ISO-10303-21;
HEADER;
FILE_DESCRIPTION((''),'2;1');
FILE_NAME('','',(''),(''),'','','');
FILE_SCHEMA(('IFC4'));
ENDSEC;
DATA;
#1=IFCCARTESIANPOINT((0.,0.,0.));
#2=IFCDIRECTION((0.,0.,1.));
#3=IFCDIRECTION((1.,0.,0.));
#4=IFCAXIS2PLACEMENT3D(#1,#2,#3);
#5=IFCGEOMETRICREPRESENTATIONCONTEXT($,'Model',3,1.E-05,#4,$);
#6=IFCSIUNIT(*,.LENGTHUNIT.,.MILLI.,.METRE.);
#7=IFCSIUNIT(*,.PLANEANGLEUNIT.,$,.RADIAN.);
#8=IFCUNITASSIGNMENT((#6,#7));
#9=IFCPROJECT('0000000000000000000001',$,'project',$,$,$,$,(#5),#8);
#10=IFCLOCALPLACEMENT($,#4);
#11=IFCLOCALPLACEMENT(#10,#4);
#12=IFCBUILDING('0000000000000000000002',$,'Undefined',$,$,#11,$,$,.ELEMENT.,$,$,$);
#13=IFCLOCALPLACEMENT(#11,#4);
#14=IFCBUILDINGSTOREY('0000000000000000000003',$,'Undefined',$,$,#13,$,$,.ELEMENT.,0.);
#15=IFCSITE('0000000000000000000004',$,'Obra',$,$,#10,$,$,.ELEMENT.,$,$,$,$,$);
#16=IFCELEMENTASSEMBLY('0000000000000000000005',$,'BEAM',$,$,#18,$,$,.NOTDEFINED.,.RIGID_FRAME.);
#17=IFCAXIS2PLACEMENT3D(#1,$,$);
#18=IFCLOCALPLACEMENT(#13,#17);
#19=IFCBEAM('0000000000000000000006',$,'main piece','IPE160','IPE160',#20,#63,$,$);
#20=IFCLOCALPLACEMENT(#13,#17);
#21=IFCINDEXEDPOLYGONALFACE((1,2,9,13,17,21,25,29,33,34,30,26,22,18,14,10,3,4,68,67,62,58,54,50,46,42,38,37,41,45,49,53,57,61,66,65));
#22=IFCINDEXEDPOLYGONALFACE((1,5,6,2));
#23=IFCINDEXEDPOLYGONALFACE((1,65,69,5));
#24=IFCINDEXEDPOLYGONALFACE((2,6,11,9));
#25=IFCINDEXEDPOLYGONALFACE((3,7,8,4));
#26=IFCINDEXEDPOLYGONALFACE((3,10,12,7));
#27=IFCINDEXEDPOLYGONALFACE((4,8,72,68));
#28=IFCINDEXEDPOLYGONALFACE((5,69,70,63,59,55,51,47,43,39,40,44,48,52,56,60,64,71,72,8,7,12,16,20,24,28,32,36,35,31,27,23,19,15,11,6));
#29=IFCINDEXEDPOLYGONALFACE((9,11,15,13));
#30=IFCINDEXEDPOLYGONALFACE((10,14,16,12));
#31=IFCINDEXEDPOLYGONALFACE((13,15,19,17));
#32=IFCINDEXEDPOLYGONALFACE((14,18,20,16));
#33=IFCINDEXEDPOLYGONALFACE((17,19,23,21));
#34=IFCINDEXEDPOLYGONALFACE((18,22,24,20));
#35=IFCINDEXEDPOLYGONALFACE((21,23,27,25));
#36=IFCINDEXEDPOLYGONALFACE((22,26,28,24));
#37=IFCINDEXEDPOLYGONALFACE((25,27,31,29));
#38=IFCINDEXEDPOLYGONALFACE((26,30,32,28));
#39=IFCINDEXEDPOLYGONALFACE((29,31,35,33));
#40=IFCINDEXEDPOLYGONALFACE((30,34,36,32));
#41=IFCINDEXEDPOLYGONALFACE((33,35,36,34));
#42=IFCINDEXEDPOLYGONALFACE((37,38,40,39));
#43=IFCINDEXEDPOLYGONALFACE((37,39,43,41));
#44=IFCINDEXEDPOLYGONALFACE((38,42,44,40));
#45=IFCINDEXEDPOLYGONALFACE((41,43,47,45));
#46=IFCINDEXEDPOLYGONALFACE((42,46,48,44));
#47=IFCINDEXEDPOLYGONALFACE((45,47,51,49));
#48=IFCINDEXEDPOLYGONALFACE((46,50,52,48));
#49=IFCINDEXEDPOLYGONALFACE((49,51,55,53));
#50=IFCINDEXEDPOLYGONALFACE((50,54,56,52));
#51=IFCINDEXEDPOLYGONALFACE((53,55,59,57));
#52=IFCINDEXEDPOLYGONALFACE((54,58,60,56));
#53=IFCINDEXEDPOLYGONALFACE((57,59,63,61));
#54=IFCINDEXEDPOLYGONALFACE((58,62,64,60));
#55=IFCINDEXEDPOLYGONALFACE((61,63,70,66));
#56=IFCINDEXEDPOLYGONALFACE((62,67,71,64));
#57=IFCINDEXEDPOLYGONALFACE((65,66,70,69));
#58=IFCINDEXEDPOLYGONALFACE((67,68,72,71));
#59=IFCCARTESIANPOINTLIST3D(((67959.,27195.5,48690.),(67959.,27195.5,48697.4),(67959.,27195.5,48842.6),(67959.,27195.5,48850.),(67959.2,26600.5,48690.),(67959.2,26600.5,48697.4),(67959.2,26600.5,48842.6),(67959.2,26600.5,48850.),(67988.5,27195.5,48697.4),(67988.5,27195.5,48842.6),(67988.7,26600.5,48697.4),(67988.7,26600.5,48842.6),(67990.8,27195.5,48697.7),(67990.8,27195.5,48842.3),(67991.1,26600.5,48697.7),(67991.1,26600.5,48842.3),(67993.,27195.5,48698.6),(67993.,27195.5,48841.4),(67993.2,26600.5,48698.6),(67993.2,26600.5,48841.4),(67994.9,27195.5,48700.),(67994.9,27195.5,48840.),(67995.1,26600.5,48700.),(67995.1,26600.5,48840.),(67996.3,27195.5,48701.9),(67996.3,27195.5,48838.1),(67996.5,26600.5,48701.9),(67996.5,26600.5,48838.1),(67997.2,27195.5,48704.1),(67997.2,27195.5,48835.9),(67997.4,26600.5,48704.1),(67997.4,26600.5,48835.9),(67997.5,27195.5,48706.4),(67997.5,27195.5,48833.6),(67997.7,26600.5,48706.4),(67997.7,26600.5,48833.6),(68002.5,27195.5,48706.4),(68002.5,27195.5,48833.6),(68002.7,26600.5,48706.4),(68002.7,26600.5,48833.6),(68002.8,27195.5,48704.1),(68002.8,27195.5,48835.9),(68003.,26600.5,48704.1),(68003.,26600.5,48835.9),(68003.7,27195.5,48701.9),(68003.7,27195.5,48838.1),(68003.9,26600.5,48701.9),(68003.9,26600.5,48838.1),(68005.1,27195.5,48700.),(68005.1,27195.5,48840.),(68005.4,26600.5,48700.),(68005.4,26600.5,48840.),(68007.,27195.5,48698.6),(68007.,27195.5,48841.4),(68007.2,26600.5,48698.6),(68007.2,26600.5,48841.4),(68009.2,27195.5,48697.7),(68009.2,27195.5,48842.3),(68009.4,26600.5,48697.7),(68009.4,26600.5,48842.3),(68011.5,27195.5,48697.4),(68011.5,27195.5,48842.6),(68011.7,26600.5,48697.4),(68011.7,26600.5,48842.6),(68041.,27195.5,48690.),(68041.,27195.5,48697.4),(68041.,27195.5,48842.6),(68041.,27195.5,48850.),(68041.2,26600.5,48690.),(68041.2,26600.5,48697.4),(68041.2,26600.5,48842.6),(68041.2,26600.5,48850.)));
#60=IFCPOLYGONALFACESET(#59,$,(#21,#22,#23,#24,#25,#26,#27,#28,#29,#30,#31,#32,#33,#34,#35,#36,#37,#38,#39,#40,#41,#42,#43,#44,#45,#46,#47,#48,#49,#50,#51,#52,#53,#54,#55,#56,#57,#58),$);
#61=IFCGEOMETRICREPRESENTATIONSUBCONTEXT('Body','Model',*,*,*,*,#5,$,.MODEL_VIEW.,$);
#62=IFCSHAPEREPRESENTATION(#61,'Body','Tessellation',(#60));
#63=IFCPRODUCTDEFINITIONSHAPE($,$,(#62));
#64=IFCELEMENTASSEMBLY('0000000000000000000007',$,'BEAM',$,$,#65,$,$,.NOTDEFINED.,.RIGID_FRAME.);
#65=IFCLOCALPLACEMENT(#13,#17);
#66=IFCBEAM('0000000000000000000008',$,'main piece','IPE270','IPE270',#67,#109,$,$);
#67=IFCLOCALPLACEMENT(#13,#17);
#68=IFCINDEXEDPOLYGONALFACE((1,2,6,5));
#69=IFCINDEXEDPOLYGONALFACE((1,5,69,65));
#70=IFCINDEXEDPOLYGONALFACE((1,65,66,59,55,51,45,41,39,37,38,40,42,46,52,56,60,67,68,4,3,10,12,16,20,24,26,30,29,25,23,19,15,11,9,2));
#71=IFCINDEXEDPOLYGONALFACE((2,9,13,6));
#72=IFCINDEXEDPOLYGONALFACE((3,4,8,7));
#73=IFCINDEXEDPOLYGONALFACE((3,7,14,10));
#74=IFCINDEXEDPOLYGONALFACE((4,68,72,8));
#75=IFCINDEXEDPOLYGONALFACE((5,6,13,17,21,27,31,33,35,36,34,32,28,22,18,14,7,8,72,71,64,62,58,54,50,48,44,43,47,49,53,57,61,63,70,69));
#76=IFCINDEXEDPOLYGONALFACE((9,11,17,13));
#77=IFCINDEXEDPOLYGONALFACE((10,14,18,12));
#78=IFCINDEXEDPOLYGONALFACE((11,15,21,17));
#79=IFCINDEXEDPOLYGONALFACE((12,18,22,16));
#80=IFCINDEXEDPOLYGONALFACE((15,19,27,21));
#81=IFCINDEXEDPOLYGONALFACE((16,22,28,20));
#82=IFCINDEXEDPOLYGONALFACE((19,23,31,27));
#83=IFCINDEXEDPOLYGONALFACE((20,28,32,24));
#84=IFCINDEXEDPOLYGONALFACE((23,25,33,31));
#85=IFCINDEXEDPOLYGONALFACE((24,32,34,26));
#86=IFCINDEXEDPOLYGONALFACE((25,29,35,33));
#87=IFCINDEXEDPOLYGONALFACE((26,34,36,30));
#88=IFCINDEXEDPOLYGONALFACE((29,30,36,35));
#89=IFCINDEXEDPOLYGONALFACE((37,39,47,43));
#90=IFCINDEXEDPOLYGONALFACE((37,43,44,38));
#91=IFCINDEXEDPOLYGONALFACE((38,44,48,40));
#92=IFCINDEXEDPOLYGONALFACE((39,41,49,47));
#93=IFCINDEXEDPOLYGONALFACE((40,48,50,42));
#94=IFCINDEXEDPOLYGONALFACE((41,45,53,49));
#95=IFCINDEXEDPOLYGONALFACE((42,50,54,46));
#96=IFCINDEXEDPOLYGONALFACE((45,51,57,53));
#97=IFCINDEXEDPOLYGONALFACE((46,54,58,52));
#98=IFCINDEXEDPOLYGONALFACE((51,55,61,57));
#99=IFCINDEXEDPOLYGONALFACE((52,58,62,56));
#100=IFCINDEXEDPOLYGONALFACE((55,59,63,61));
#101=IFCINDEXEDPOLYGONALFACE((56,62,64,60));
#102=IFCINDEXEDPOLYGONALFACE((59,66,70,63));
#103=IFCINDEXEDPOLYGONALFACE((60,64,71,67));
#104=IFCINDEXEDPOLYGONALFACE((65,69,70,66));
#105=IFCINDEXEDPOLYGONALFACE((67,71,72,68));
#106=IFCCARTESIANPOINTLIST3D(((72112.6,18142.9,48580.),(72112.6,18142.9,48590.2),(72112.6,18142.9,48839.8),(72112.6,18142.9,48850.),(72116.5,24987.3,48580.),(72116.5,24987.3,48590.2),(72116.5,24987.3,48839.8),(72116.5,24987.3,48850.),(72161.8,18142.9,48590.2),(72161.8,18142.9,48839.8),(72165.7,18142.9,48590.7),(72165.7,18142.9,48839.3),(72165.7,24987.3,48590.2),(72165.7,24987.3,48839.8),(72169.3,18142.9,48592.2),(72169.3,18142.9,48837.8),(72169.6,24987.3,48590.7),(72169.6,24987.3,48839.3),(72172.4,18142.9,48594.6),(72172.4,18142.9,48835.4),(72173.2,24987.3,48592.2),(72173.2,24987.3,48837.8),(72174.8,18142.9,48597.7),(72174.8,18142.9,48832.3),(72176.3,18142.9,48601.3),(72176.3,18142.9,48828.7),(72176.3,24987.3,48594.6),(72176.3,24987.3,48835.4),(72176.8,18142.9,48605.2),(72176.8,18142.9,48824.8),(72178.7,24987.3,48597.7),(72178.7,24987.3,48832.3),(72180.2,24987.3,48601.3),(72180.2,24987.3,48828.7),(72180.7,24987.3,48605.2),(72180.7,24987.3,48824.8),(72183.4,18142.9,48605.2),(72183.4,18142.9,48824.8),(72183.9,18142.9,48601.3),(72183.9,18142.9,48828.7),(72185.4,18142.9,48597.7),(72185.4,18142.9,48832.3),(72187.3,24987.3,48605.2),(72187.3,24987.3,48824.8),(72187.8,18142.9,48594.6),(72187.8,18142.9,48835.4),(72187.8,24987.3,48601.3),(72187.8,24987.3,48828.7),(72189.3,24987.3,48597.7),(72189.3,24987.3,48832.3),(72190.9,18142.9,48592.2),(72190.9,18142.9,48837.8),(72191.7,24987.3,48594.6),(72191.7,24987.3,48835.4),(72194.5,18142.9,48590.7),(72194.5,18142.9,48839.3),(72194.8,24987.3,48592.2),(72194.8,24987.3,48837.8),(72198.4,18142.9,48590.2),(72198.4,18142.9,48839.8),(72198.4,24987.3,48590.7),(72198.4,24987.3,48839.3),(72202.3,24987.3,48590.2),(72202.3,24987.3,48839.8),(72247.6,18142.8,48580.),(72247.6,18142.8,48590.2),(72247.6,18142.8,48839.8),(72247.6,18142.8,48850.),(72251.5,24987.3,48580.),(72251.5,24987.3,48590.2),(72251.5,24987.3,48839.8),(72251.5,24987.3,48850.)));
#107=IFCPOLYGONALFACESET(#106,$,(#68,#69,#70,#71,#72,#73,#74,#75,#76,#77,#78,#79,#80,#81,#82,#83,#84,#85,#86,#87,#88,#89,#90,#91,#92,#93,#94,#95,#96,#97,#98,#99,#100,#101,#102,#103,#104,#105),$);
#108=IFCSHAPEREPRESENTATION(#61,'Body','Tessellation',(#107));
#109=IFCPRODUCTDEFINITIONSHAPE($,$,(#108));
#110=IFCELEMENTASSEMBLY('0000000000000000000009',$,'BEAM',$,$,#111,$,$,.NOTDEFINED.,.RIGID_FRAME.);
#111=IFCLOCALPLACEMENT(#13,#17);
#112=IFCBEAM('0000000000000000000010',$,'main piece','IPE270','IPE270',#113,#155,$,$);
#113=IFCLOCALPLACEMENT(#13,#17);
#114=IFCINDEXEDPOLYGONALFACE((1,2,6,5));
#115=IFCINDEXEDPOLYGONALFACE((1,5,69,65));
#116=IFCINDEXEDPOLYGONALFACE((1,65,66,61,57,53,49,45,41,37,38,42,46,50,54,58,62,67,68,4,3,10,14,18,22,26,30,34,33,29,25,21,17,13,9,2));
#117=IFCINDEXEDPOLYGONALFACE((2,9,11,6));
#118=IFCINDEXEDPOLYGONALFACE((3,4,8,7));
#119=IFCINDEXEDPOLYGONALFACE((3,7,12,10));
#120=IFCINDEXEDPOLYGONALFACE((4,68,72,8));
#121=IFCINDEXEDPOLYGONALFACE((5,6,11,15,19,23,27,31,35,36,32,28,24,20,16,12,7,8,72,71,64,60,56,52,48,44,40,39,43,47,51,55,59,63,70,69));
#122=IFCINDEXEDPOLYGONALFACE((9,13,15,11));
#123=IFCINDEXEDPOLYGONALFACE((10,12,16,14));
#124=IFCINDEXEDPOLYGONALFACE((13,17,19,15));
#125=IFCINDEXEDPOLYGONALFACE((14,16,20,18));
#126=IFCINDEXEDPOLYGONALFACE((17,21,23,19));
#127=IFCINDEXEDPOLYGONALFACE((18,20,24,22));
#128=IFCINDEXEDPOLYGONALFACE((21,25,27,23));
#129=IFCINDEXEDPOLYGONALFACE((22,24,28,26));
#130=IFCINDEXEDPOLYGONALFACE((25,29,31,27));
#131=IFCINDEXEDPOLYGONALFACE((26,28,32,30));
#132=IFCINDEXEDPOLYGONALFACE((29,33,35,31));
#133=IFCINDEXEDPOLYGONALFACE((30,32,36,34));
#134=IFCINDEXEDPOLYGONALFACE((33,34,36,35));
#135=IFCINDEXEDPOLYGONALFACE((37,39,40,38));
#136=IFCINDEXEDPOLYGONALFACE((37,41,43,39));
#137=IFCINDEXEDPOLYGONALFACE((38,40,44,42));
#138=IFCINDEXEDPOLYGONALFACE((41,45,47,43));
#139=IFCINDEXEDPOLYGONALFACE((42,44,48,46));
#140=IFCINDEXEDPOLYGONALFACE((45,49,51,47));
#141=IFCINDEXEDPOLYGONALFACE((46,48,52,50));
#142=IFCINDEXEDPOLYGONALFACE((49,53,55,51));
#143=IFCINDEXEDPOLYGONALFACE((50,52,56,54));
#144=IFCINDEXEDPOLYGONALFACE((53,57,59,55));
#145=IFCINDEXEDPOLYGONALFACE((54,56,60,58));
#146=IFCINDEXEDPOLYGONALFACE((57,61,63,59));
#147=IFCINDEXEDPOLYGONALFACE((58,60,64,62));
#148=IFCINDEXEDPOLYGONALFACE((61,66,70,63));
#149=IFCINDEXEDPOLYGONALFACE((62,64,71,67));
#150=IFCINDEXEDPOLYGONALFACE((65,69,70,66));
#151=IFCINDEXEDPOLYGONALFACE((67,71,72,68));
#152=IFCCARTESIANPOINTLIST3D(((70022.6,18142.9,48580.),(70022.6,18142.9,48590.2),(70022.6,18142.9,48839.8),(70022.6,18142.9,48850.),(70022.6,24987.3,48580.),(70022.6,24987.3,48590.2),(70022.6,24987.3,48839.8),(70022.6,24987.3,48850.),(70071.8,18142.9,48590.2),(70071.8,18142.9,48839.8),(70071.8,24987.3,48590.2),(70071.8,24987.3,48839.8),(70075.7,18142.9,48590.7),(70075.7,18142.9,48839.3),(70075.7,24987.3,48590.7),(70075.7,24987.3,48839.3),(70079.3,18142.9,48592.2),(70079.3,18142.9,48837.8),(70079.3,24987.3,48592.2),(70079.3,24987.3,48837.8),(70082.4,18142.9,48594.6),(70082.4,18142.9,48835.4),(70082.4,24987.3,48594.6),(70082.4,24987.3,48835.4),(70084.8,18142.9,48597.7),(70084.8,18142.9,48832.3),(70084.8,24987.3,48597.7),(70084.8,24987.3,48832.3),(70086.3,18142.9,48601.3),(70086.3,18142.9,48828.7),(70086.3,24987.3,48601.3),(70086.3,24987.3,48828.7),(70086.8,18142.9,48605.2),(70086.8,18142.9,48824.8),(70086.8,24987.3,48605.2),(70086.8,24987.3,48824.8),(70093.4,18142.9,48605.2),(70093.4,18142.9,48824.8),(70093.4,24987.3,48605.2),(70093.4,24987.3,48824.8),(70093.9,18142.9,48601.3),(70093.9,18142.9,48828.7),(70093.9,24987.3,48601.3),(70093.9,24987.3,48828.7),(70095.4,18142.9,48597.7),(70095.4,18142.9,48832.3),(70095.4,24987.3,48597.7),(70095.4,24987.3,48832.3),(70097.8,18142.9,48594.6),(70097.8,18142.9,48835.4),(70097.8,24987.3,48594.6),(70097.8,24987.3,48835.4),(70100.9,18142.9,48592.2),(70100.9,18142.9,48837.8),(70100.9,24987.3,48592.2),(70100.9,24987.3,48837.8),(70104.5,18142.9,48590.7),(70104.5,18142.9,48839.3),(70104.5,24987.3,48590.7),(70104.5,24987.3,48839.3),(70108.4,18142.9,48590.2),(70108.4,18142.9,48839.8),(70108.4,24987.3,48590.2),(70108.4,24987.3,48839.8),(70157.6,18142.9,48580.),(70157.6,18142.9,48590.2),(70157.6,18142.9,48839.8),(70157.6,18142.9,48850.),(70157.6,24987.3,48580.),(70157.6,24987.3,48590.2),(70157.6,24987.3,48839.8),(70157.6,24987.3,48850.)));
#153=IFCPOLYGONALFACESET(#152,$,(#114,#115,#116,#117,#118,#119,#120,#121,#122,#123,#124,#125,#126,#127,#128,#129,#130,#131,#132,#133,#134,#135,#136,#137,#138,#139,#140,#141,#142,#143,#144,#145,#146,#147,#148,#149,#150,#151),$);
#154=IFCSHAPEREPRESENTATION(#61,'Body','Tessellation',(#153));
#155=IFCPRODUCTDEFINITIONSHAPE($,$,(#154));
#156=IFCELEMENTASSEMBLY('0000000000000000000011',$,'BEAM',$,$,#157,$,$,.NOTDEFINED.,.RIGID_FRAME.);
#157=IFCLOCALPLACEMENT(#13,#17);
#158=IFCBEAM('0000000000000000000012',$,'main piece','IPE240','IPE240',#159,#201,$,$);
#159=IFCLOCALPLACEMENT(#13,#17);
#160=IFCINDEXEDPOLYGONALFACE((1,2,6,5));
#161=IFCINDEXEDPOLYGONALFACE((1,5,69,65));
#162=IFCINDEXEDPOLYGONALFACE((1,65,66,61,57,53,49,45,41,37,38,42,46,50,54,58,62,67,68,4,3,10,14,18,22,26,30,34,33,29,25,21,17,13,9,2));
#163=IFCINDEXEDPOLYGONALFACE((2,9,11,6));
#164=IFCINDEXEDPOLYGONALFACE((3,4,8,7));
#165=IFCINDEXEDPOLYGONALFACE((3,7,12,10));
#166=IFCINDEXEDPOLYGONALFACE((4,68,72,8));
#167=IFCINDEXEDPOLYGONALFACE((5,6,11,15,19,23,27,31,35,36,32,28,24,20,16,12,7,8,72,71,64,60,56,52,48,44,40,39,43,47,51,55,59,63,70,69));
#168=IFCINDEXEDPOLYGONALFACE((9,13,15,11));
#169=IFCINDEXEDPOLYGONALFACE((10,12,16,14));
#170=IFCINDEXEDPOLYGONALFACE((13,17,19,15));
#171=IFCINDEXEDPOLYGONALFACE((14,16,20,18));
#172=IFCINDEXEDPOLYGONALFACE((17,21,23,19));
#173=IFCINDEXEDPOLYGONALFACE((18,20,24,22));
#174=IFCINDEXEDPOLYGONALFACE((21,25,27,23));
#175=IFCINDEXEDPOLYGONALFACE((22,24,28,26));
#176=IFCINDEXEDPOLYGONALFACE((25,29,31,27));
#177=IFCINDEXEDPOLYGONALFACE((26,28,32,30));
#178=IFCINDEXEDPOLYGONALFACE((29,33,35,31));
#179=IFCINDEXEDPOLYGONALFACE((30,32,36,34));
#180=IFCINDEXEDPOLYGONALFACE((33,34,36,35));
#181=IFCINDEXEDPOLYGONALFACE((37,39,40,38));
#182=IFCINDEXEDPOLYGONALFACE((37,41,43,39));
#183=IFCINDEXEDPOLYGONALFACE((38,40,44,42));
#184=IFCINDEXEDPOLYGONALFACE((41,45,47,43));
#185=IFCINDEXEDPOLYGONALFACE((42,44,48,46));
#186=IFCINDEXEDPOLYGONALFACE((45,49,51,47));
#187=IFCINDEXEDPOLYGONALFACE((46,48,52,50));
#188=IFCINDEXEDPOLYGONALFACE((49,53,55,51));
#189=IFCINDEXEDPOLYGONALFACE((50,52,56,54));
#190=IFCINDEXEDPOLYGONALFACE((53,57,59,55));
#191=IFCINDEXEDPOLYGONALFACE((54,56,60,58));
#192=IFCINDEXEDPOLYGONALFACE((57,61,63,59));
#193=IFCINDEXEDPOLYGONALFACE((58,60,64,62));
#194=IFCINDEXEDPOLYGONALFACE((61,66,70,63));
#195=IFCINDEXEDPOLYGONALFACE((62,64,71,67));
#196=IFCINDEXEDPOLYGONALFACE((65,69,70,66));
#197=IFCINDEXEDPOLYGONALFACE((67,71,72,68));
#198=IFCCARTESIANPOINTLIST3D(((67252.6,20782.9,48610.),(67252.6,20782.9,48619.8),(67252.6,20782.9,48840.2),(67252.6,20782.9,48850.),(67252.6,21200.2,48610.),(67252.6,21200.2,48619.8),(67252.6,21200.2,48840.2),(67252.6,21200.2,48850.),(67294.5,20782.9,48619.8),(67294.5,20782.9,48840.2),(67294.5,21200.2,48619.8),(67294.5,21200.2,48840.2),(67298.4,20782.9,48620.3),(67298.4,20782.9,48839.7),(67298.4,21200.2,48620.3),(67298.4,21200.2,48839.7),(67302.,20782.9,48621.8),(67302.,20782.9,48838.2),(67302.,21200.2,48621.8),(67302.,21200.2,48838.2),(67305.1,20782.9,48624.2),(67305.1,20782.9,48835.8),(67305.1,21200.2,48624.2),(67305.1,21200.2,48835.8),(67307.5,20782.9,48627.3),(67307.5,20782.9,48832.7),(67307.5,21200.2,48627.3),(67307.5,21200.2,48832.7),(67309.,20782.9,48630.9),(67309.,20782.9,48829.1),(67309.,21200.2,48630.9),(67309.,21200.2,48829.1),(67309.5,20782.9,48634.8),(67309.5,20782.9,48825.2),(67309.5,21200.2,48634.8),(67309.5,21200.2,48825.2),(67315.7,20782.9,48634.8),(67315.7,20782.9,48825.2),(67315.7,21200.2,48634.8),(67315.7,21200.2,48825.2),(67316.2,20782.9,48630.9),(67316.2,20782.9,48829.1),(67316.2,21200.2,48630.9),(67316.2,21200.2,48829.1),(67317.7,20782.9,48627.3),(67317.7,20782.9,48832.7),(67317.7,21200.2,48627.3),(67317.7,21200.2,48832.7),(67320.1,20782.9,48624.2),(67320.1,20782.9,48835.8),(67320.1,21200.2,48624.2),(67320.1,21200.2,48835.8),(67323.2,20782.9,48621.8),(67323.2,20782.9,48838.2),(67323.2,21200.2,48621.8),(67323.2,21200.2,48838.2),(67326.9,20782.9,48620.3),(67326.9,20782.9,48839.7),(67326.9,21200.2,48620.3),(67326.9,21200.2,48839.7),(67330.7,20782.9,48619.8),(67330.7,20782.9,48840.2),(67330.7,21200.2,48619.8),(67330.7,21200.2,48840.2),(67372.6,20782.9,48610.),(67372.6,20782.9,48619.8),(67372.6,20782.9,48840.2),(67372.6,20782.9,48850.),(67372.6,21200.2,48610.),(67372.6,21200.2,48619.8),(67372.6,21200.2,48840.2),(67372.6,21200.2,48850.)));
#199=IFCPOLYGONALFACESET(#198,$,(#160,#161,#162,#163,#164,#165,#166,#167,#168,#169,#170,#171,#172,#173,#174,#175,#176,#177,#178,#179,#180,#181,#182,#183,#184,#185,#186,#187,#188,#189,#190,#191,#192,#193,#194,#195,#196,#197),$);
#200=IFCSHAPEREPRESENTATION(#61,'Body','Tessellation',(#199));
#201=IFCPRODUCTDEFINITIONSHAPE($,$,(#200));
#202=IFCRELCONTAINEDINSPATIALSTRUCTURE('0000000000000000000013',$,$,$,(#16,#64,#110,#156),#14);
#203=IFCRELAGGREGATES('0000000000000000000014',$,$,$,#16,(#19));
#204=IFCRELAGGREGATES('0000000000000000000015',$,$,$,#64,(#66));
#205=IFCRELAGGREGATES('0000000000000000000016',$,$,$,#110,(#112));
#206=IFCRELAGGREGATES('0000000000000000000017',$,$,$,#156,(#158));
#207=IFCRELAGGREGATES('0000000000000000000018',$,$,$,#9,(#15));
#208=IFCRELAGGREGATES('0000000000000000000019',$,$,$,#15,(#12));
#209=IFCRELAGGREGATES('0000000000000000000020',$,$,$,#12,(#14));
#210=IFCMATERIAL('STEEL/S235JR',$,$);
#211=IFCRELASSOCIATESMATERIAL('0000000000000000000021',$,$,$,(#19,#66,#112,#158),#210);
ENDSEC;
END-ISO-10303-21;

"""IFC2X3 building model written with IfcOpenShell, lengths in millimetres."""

from ifc_helpers import new_model, si_unit, frame, origin_with_axes, origin_2d_with_axis, place, context, subcontext, project, spatial, i_section, extrude, material, element, aggregate, save


model = new_model("IFC2X3")

# Units and contexts
model_context = context("Model", 3, precision=1e-05, world=origin_with_axes())
body_context = subcontext(model_context, "Body", "Model", "MODEL_VIEW")
ifc_project = project(units=[si_unit("LENGTHUNIT", "METRE", prefix="MILLI"), si_unit("PLANEANGLEUNIT", "RADIAN")], contexts=[model_context])

# Site, building, storey
site_placement = place(None, origin_with_axes())
site = spatial("IfcSite", under=ifc_project, at=site_placement, Name="Obra", CompositionType="ELEMENT")
building_placement = place(site_placement, origin_with_axes())
building = spatial("IfcBuilding", under=site, at=building_placement, Name="Undefined", CompositionType="ELEMENT")
storey_placement = place(building_placement, origin_with_axes())
storey = spatial("IfcBuildingStorey", under=building, at=storey_placement, Name="Undefined", CompositionType="ELEMENT", Elevation=0.0)

# Shared definitions
ifc_material_1 = material(Name="STEEL/S235JR")

# Element assemblies, beams
assembly_1_placement = place(storey_placement, origin_with_axes())
assembly_1 = element("IfcElementAssembly", 1, at=assembly_1_placement, inside=storey, Name="BEAM", AssemblyPlace="NOTDEFINED", PredefinedType="RIGID_FRAME")
beam_1_placement = place(assembly_1_placement, frame((68000.2, 26600.5, 48770.0), z_axis=(0.0, 0.0, 1.0), x_axis=(-0.000391, 1.0, 0.0)))
beam_1 = element("IfcBeam", 2, at=beam_1_placement, material=ifc_material_1, Name="main piece", Description="IPE160", ObjectType="IPE160", context=body_context, shape_type="SweptSolid", body=[
    extrude(i_section(OverallWidth=82.0, OverallDepth=160.0, WebThickness=5.0, FlangeThickness=7.4, FilletRadius=9.0, at=origin_2d_with_axis()), frame((595.0, 0.0, 0.0), z_axis=(-1.0, 0.0, 0.0), x_axis=(0.0, -1.0, 0.0)), (0.0, 0.0, 1.0), 595.0),
])
aggregate(assembly_1, [beam_1])
assembly_2_placement = place(storey_placement, origin_with_axes())
assembly_2 = element("IfcElementAssembly", 3, at=assembly_2_placement, inside=storey, Name="BEAM", AssemblyPlace="NOTDEFINED", PredefinedType="RIGID_FRAME")
beam_2_placement = place(assembly_2_placement, frame((72184.0, 24987.3, 48715.0), z_axis=(0.0, 0.0, 1.0), x_axis=(-0.000568, -1.0, 0.0)))
beam_2 = element("IfcBeam", 4, at=beam_2_placement, material=ifc_material_1, Name="main piece", Description="IPE270", ObjectType="IPE270", context=body_context, shape_type="SweptSolid", body=[
    extrude(i_section(OverallWidth=135.0, OverallDepth=270.0, WebThickness=6.6, FlangeThickness=10.2, FilletRadius=15.0, at=origin_2d_with_axis()), frame((6844.4, 0.0, 0.0), z_axis=(-1.0, 0.0, 0.0), x_axis=(0.0, -1.0, 0.0)), (0.0, 0.0, 1.0), 6844.4),
])
aggregate(assembly_2, [beam_2])
assembly_3_placement = place(storey_placement, origin_with_axes())
assembly_3 = element("IfcElementAssembly", 5, at=assembly_3_placement, inside=storey, Name="BEAM", AssemblyPlace="NOTDEFINED", PredefinedType="RIGID_FRAME")
beam_3_placement = place(assembly_3_placement, frame((70090.1, 18142.9, 48715.0), z_axis=(0.0, 0.0, 1.0), x_axis=(0.0, 1.0, 0.0)))
beam_3 = element("IfcBeam", 6, at=beam_3_placement, material=ifc_material_1, Name="main piece", Description="IPE270", ObjectType="IPE270", context=body_context, shape_type="SweptSolid", body=[
    extrude(i_section(OverallWidth=135.0, OverallDepth=270.0, WebThickness=6.6, FlangeThickness=10.2, FilletRadius=15.0, at=origin_2d_with_axis()), frame((6844.4, 0.0, 0.0), z_axis=(-1.0, 0.0, 0.0), x_axis=(0.0, -1.0, 0.0)), (0.0, 0.0, 1.0), 6844.4),
])
aggregate(assembly_3, [beam_3])
assembly_4_placement = place(storey_placement, origin_with_axes())
assembly_4 = element("IfcElementAssembly", 7, at=assembly_4_placement, inside=storey, Name="BEAM", AssemblyPlace="NOTDEFINED", PredefinedType="RIGID_FRAME")
beam_4_placement = place(assembly_4_placement, frame((67312.6, 20782.9, 48730.0), z_axis=(0.0, 0.0, 1.0), x_axis=(0.0, 1.0, 0.0)))
beam_4 = element("IfcBeam", 8, at=beam_4_placement, material=ifc_material_1, Name="main piece", Description="IPE240", ObjectType="IPE240", context=body_context, shape_type="SweptSolid", body=[
    extrude(i_section(OverallWidth=120.0, OverallDepth=240.0, WebThickness=6.2, FlangeThickness=9.8, FilletRadius=15.0, at=origin_2d_with_axis()), frame((417.2, 0.0, 0.0), z_axis=(-1.0, 0.0, 0.0), x_axis=(0.0, -1.0, 0.0)), (0.0, 0.0, 1.0), 417.2),
])
aggregate(assembly_4, [beam_4])

save(model, "model.ifc")
